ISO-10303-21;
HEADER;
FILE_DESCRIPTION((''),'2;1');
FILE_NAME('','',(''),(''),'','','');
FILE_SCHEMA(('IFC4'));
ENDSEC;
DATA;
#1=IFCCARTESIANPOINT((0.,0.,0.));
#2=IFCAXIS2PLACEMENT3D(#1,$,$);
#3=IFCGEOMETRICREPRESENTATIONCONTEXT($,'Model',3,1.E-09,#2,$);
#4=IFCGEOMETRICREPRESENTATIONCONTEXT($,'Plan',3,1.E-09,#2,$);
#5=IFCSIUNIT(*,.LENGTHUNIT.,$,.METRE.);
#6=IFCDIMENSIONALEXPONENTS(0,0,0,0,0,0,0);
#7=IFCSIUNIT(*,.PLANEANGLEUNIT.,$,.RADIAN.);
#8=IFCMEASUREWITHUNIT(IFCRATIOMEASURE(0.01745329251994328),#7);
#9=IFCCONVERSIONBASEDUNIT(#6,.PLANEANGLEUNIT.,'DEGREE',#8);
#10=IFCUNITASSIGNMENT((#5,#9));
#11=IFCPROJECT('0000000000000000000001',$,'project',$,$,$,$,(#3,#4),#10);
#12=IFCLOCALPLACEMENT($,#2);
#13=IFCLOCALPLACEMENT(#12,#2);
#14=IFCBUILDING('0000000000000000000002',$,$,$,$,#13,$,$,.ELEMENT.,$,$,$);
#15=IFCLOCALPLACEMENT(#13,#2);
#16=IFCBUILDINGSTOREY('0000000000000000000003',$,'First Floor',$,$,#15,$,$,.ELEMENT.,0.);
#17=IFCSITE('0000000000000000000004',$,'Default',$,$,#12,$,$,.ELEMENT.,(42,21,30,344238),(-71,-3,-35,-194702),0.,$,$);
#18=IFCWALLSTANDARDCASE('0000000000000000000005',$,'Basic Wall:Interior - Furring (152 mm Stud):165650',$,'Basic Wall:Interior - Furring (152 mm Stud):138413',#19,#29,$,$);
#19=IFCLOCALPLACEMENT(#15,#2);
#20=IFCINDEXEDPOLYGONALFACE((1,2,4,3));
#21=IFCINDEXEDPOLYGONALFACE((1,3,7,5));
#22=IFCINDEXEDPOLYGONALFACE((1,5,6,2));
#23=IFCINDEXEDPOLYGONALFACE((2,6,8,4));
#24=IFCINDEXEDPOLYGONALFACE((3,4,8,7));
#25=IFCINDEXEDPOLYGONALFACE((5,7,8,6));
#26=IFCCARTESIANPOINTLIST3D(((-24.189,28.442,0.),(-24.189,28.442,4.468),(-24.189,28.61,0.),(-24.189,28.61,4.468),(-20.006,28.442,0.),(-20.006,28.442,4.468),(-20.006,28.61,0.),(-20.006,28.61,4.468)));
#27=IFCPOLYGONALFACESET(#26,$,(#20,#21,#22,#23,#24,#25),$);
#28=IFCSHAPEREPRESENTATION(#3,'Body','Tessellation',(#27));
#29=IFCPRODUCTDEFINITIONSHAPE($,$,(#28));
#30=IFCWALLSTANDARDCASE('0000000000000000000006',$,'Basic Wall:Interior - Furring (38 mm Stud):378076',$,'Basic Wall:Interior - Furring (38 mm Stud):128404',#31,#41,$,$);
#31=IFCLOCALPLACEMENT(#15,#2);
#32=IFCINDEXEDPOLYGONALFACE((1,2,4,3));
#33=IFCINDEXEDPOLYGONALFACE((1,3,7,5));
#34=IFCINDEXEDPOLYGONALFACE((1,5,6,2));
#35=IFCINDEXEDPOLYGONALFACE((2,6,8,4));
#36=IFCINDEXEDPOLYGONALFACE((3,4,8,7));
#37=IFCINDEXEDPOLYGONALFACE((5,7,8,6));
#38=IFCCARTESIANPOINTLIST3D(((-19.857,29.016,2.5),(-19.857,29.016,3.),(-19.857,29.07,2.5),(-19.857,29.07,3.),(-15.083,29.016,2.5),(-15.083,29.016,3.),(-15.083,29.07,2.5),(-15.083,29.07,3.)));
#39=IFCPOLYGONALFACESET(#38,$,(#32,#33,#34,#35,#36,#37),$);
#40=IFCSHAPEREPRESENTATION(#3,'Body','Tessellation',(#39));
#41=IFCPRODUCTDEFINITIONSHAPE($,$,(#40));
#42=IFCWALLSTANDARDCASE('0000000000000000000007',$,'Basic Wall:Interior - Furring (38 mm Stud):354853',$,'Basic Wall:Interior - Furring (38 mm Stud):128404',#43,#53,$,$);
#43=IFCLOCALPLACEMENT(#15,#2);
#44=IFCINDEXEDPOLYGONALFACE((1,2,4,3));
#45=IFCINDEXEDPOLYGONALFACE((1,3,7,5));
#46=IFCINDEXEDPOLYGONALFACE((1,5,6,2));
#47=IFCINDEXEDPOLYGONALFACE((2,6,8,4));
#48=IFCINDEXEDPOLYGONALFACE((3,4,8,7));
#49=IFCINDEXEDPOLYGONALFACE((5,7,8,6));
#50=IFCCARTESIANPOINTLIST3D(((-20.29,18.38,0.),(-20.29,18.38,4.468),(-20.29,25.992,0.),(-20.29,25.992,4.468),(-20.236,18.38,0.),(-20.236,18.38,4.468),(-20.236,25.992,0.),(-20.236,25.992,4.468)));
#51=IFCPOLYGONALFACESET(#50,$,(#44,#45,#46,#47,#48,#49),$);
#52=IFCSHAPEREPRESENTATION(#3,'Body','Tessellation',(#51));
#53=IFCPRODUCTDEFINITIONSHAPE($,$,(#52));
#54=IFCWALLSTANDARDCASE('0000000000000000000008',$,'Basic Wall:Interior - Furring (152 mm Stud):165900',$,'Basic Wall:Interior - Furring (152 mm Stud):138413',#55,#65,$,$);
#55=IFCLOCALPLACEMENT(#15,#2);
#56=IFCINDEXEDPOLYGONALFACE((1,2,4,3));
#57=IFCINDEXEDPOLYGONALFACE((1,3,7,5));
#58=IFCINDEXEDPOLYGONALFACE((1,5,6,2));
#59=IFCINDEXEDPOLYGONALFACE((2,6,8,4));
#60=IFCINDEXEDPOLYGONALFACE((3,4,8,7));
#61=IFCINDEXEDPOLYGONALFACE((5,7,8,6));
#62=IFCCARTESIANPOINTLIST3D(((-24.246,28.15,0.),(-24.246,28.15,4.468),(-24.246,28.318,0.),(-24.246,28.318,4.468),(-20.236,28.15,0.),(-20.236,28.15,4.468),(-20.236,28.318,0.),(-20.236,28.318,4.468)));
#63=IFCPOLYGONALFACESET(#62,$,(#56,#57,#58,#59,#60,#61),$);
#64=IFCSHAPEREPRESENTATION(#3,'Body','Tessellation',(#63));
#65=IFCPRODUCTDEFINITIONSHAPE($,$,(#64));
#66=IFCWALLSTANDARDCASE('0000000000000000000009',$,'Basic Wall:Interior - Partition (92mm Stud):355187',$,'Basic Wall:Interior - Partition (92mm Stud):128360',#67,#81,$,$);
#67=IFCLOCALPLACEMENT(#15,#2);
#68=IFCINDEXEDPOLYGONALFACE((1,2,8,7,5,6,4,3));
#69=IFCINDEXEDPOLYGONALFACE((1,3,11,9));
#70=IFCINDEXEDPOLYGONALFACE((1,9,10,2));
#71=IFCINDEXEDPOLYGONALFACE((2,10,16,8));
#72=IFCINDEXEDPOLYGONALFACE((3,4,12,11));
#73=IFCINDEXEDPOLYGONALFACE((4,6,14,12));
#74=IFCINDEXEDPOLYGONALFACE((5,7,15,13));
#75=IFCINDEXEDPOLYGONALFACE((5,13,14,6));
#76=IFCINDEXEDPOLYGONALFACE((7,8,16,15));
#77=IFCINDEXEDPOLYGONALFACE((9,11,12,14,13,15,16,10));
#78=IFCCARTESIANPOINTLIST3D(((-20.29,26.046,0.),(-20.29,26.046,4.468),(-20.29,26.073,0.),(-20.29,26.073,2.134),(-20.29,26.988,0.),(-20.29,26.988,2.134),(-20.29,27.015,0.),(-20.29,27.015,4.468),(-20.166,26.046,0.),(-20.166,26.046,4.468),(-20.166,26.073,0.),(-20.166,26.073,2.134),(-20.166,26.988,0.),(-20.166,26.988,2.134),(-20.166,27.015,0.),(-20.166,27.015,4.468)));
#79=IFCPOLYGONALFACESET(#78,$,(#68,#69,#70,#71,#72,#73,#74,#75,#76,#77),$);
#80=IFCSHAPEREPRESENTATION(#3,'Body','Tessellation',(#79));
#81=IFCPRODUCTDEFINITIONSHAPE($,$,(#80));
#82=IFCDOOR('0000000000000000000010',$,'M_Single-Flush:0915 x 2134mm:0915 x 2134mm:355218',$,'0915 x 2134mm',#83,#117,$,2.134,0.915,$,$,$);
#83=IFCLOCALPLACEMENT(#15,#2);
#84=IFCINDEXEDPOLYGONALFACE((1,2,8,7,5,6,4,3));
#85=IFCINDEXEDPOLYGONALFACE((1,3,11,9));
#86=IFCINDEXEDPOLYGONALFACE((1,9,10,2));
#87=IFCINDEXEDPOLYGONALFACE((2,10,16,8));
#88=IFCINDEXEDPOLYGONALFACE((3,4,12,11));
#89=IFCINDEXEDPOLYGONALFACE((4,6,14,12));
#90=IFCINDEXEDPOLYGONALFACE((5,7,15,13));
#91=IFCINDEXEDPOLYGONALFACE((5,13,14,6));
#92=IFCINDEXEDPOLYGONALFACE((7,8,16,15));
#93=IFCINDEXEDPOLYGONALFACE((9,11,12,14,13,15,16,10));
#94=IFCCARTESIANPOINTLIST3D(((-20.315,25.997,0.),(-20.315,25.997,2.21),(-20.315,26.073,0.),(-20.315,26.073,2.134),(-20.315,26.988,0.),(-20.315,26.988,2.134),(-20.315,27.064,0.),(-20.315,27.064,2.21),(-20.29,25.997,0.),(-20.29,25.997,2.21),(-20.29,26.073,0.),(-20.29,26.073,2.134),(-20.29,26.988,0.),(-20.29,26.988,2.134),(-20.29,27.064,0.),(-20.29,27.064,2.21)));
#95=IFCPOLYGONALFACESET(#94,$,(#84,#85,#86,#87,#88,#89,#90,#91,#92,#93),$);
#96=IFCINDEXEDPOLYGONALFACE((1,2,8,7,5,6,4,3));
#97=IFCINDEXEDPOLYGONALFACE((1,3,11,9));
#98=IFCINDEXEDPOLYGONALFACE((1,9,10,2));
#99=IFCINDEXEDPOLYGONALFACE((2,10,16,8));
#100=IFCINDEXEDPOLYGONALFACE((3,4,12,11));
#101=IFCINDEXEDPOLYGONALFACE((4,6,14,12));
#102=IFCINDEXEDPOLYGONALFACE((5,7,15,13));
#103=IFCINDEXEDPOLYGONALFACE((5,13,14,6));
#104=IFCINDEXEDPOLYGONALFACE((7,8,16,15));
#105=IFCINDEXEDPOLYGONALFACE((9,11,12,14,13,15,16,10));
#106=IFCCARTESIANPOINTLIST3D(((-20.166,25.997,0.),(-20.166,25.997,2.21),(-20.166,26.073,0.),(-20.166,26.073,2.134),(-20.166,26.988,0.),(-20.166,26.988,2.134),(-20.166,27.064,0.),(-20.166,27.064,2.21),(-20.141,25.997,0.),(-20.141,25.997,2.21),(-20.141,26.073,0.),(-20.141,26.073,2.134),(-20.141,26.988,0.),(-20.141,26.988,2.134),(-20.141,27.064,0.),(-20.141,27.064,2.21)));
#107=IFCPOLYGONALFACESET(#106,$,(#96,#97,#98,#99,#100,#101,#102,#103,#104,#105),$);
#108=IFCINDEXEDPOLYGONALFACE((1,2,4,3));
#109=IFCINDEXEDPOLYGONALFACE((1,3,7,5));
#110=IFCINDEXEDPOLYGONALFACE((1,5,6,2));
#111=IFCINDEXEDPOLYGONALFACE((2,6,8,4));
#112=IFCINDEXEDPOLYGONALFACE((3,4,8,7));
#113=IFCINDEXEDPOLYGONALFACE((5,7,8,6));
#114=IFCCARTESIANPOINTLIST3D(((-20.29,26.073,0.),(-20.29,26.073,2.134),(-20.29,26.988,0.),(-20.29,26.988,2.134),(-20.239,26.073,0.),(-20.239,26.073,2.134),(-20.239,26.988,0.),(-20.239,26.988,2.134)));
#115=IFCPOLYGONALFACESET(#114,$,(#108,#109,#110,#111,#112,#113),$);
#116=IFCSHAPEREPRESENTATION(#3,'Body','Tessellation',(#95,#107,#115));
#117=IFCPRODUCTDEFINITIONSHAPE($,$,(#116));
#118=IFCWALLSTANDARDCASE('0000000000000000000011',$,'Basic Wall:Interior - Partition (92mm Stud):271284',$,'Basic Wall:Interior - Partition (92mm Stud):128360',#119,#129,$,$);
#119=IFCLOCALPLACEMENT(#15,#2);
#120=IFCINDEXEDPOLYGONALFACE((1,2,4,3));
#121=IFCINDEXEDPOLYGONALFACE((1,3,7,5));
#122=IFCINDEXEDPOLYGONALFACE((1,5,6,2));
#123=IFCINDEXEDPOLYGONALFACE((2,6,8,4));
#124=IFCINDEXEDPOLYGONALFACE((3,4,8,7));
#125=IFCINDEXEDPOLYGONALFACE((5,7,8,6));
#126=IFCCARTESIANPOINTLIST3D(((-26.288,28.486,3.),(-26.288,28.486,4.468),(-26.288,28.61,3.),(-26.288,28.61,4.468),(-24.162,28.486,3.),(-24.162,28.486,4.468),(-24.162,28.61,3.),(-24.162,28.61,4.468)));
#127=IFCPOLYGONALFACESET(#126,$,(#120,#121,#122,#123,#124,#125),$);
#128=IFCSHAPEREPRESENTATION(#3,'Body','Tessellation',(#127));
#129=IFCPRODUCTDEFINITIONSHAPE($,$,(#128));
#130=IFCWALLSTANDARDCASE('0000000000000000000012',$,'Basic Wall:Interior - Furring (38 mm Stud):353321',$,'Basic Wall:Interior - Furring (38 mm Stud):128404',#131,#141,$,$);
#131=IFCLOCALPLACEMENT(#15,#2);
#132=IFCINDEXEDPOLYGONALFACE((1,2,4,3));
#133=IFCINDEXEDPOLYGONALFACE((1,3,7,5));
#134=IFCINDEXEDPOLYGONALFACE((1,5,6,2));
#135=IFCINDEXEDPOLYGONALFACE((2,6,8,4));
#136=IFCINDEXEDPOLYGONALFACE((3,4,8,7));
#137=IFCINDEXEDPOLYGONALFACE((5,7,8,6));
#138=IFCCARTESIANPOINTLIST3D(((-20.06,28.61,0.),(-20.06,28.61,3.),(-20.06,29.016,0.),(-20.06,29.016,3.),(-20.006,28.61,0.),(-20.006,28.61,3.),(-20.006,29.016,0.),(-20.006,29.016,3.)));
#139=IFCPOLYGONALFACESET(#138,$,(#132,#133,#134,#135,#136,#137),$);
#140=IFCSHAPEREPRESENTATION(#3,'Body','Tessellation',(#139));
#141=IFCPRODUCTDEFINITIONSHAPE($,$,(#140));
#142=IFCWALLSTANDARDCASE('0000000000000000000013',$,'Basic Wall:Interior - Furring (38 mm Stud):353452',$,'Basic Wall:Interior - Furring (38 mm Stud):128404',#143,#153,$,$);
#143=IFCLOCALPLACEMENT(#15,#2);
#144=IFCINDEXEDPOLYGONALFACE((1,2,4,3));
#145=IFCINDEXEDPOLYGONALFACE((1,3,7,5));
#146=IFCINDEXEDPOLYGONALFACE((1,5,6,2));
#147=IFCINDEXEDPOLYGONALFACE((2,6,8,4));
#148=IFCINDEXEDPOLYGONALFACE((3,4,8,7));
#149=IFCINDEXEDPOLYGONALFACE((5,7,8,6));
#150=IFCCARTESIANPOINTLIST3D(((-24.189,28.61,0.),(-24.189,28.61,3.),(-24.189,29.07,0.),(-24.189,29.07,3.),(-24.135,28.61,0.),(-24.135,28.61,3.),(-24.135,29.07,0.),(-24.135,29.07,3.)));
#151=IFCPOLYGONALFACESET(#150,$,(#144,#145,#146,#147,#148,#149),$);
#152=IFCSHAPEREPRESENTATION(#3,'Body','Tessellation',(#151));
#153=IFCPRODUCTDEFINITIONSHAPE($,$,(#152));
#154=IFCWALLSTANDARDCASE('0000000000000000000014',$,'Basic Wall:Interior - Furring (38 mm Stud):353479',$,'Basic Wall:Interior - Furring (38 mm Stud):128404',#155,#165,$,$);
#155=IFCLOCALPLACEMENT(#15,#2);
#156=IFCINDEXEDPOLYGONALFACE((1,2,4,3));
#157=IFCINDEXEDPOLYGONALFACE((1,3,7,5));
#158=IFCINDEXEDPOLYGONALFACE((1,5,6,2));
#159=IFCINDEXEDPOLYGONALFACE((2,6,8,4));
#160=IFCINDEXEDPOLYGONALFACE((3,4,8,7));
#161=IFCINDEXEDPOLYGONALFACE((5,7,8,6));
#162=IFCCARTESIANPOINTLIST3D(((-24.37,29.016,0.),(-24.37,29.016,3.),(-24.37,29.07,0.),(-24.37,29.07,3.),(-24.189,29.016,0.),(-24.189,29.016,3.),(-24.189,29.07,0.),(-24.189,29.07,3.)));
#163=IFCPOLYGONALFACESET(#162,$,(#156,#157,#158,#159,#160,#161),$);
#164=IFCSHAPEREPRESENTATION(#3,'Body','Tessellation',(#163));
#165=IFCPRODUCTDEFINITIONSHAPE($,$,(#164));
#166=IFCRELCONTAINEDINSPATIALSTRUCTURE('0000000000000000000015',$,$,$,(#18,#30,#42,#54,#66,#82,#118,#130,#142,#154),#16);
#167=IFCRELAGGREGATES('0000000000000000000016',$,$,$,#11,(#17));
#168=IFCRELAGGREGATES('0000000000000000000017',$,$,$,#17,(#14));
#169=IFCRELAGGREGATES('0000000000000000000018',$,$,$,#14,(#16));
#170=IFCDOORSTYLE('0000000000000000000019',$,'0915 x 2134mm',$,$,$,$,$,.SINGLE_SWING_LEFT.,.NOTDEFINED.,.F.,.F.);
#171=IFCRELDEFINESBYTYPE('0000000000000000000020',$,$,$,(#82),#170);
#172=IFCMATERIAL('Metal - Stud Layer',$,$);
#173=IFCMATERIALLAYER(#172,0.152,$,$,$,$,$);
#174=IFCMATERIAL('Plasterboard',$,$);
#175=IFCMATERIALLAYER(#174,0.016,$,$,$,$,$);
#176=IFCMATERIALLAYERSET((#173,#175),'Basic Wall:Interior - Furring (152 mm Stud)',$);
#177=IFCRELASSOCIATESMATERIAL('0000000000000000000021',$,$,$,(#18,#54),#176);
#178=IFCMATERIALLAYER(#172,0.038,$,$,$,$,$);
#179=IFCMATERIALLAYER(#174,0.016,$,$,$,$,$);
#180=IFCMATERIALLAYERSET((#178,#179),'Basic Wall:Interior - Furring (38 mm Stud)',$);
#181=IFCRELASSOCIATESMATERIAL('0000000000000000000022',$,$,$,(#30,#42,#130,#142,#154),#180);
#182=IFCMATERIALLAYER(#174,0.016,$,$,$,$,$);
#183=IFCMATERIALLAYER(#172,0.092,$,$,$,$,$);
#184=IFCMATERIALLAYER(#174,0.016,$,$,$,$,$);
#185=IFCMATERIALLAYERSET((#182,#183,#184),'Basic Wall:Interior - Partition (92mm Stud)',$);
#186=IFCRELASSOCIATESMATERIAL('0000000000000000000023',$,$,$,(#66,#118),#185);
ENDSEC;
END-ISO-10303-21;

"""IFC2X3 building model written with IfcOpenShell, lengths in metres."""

from ifc_helpers import new_model, entity, si_unit, converted_unit, frame, frame_2d, origin, origin_2d_with_axis, place, context, project, spatial, polyline, rectangle, outline, extrude, source, transform, mapped, material, layer, layer_set, layer_usage, type_object, type_shapes, element, fill, save


model = new_model("IFC2X3")

# Units and contexts
model_context = context("Model", 3, precision=1e-09, world=origin())
plan_context = context("Plan", 3, precision=1e-09, world=origin())
ifc_project = project(units=[si_unit("LENGTHUNIT", "METRE"), converted_unit("PLANEANGLEUNIT", "DEGREE", entity("IfcRatioMeasure", 0.01745329251994328), si_unit("PLANEANGLEUNIT", "RADIAN"), dimensions=[0, 0, 0, 0, 0, 0, 0])], contexts=[model_context, plan_context])

# Site, building, storey
site_placement = place(None, origin())
site = spatial("IfcSite", under=ifc_project, at=site_placement, Name="Default", CompositionType="ELEMENT", RefLatitude=(42, 21, 30, 344238), RefLongitude=(-71, -3, -35, -194702), RefElevation=0.0)
building_placement = place(site_placement, origin())
building = spatial("IfcBuilding", under=site, at=building_placement, CompositionType="ELEMENT")
storey_placement = place(building_placement, origin())
storey = spatial("IfcBuildingStorey", under=building, at=storey_placement, Name="First Floor", CompositionType="ELEMENT", Elevation=0.0)

# Shared definitions
ifc_material_1 = material(Name="Metal - Stud Layer")
ifc_layer_1 = layer(ifc_material_1, 0.152)
ifc_material_2 = material(Name="Plasterboard")
ifc_layer_2 = layer(ifc_material_2, 0.016)
ifc_layer_set_1 = layer_set([ifc_layer_1, ifc_layer_2], Name="Basic Wall:Interior - Furring (152 mm Stud)")
ifc_layer_usage_1 = layer_usage(ifc_layer_set_1, "AXIS2", "POSITIVE", -0.084)

# Walls
wall_1_placement = place(storey_placement, frame((-24.189, 28.526, 0.0)))
element("IfcWallStandardCase", 1, at=wall_1_placement, inside=storey, material=ifc_layer_usage_1, Name="Basic Wall:Interior - Furring (152 mm Stud):165650", ObjectType="Basic Wall:Interior - Furring (152 mm Stud):138413", context=model_context, shape_type="SweptSolid", body=[
    extrude(rectangle(XDim=4.183, YDim=0.168, at=frame_2d((2.0915, 0.0), x_axis=(-1.0, 0.0))), origin(), (0.0, 0.0, 1.0), 4.468),
])
ifc_layer_3 = layer(ifc_material_1, 0.038)
ifc_layer_4 = layer(ifc_material_2, 0.016)
ifc_layer_set_2 = layer_set([ifc_layer_3, ifc_layer_4], Name="Basic Wall:Interior - Furring (38 mm Stud)")
ifc_layer_usage_2 = layer_usage(ifc_layer_set_2, "AXIS2", "POSITIVE", -0.027)
wall_2_placement = place(storey_placement, frame((-19.857, 29.043, 2.5)))
element("IfcWallStandardCase", 2, at=wall_2_placement, inside=storey, material=ifc_layer_usage_2, Name="Basic Wall:Interior - Furring (38 mm Stud):378076", ObjectType="Basic Wall:Interior - Furring (38 mm Stud):128404", context=model_context, shape_type="SweptSolid", body=[
    extrude(rectangle(XDim=4.774, YDim=0.054, at=frame_2d((2.387, 0.0), x_axis=(-1.0, 0.0))), origin(), (0.0, 0.0, 1.0), 0.5),
])
ifc_layer_usage_3 = layer_usage(ifc_layer_set_2, "AXIS2", "NEGATIVE", 0.027)
wall_3_placement = place(storey_placement, frame((-20.263, 25.992, 0.0), z_axis=(0.0, 0.0, 1.0), x_axis=(0.0, -1.0, 0.0)))
element("IfcWallStandardCase", 3, at=wall_3_placement, inside=storey, material=ifc_layer_usage_3, Name="Basic Wall:Interior - Furring (38 mm Stud):354853", ObjectType="Basic Wall:Interior - Furring (38 mm Stud):128404", context=model_context, shape_type="SweptSolid", body=[
    extrude(rectangle(XDim=7.612, YDim=0.054, at=frame_2d((3.806, 0.0), x_axis=(-1.0, 0.0))), origin(), (0.0, 0.0, 1.0), 4.468),
])
wall_4_placement = place(storey_placement, frame((-20.236, 28.234, 0.0), z_axis=(0.0, 0.0, 1.0), x_axis=(-1.0, 0.0, 0.0)))
element("IfcWallStandardCase", 4, at=wall_4_placement, inside=storey, material=ifc_layer_usage_1, Name="Basic Wall:Interior - Furring (152 mm Stud):165900", ObjectType="Basic Wall:Interior - Furring (152 mm Stud):138413", context=model_context, shape_type="SweptSolid", body=[
    extrude(rectangle(XDim=4.01, YDim=0.168, at=frame_2d((2.005, 0.0), x_axis=(-1.0, 0.0))), origin(), (0.0, 0.0, 1.0), 4.468),
])

# Wall, opening, door
ifc_layer_5 = layer(ifc_material_2, 0.016)
ifc_layer_6 = layer(ifc_material_1, 0.092)
ifc_layer_7 = layer(ifc_material_2, 0.016)
ifc_layer_set_3 = layer_set([ifc_layer_5, ifc_layer_6, ifc_layer_7], Name="Basic Wall:Interior - Partition (92mm Stud)")
ifc_layer_usage_4 = layer_usage(ifc_layer_set_3, "AXIS2", "POSITIVE", -0.062)
wall_5_placement = place(storey_placement, frame((-20.228, 27.015, 0.0), z_axis=(0.0, 0.0, 1.0), x_axis=(0.0, -1.0, 0.0)))
wall_5 = element("IfcWallStandardCase", 5, at=wall_5_placement, inside=storey, material=ifc_layer_usage_4, Name="Basic Wall:Interior - Partition (92mm Stud):355187", ObjectType="Basic Wall:Interior - Partition (92mm Stud):128360", context=model_context, shape_type="SweptSolid", body=[
    extrude(rectangle(XDim=0.969, YDim=0.124, at=frame_2d((0.4845, 0.0), x_axis=(-1.0, 0.0))), origin(), (0.0, 0.0, 1.0), 4.468),
])
opening_1_placement = place(wall_5_placement, frame((0.942, 0.062, 0.0)))
opening_1 = element("IfcOpeningElement", 6, at=opening_1_placement, cuts=wall_5, ObjectType="Opening", context=model_context, shape_type="SweptSolid", body=[
    extrude(rectangle(XDim=0.915, YDim=2.134, at=frame_2d((1.067, 0.4575), x_axis=(0.0, -1.0))), frame((0.0, 0.0, 0.0), z_axis=(0.0, -1.0, 0.0), x_axis=(0.0, 0.0, 1.0)), (0.0, 0.0, 1.0), 0.124),
])
door_style = type_object("IfcDoorStyle", Name="0915 x 2134mm", ConstructionType="NOTDEFINED", OperationType="SINGLE_SWING_LEFT", ParameterTakesPrecedence=False, Sizeable=False)
shared_shape_1 = source(origin(), model_context, "Body", "SweptSolid", [
    extrude(outline(polyline([(-0.5335, -1.124), (0.5335, -1.124), (0.5335, 1.086), (0.4575, 1.086), (0.4575, -1.048), (-0.4575, -1.048), (-0.4575, 1.086), (-0.5335, 1.086), (-0.5335, -1.124)])), frame((0.4575, 0.149, 1.086), z_axis=(0.0, -1.0, 0.0), x_axis=(-1.0, 0.0, 0.0)), (0.0, 0.0, 1.0), 0.025),
    extrude(outline(polyline([(-1.124, -0.5335), (1.086, -0.5335), (1.086, -0.4575), (-1.048, -0.4575), (-1.048, 0.4575), (1.086, 0.4575), (1.086, 0.5335), (-1.124, 0.5335), (-1.124, -0.5335)])), frame((0.4575, 0.0, 1.086), z_axis=(0.0, -1.0, 0.0), x_axis=(0.0, 0.0, -1.0)), (0.0, 0.0, 1.0), 0.025),
    extrude(rectangle(XDim=0.915, YDim=0.051, at=origin_2d_with_axis()), frame((0.4575, 0.0985, 0.0)), (0.0, 0.0, 1.0), 2.134),
])
type_shapes(door_style, [shared_shape_1])
door_placement = place(opening_1_placement, frame((0.0, 0.0, 0.0), z_axis=(0.0, 0.0, 1.0), x_axis=(-1.0, 0.0, 0.0)))
door = element("IfcDoor", 7, at=door_placement, inside=storey, type_object=door_style, Name="M_Single-Flush:0915 x 2134mm:0915 x 2134mm:355218", ObjectType="0915 x 2134mm", OverallHeight=2.134, OverallWidth=0.915, context=model_context, shape_type="MappedRepresentation", body=[
    mapped(shared_shape_1, transform((0.0, 0.0, 0.0), scale=1.0)),
])
fill(opening_1, door)

# Walls
ifc_layer_usage_5 = layer_usage(ifc_layer_set_3, "AXIS2", "NEGATIVE", 0.062)
wall_6_placement = place(storey_placement, frame((-24.162, 28.548, 3.0), z_axis=(0.0, 0.0, 1.0), x_axis=(-1.0, 0.0, 0.0)))
element("IfcWallStandardCase", 8, at=wall_6_placement, inside=storey, material=ifc_layer_usage_5, Name="Basic Wall:Interior - Partition (92mm Stud):271284", ObjectType="Basic Wall:Interior - Partition (92mm Stud):128360", context=model_context, shape_type="SweptSolid", body=[
    extrude(rectangle(XDim=2.126, YDim=0.124, at=frame_2d((1.063, 0.0), x_axis=(-1.0, 0.0))), origin(), (0.0, 0.0, 1.0), 1.468),
])
wall_7_placement = place(storey_placement, frame((-20.033, 29.016, 0.0), z_axis=(0.0, 0.0, 1.0), x_axis=(0.0, -1.0, 0.0)))
element("IfcWallStandardCase", 9, at=wall_7_placement, inside=storey, material=ifc_layer_usage_3, Name="Basic Wall:Interior - Furring (38 mm Stud):353321", ObjectType="Basic Wall:Interior - Furring (38 mm Stud):128404", context=model_context, shape_type="SweptSolid", body=[
    extrude(rectangle(XDim=0.406, YDim=0.054, at=frame_2d((0.203, 0.0), x_axis=(-1.0, 0.0))), origin(), (0.0, 0.0, 1.0), 3.0),
])
wall_8_placement = place(storey_placement, frame((-24.162, 28.61, 0.0), z_axis=(0.0, 0.0, 1.0), x_axis=(0.0, 1.0, 0.0)))
element("IfcWallStandardCase", 10, at=wall_8_placement, inside=storey, material=ifc_layer_usage_3, Name="Basic Wall:Interior - Furring (38 mm Stud):353452", ObjectType="Basic Wall:Interior - Furring (38 mm Stud):128404", context=model_context, shape_type="SweptSolid", body=[
    extrude(rectangle(XDim=0.46, YDim=0.054, at=frame_2d((0.23, 0.0), x_axis=(-1.0, 0.0))), origin(), (0.0, 0.0, 1.0), 3.0),
])
wall_9_placement = place(storey_placement, frame((-24.189, 29.043, 0.0), z_axis=(0.0, 0.0, 1.0), x_axis=(-1.0, 0.0, 0.0)))
element("IfcWallStandardCase", 11, at=wall_9_placement, inside=storey, material=ifc_layer_usage_3, Name="Basic Wall:Interior - Furring (38 mm Stud):353479", ObjectType="Basic Wall:Interior - Furring (38 mm Stud):128404", context=model_context, shape_type="SweptSolid", body=[
    extrude(rectangle(XDim=0.181, YDim=0.054, at=frame_2d((0.0905, 0.0), x_axis=(-1.0, 0.0))), origin(), (0.0, 0.0, 1.0), 3.0),
])

save(model, "model.ifc")
